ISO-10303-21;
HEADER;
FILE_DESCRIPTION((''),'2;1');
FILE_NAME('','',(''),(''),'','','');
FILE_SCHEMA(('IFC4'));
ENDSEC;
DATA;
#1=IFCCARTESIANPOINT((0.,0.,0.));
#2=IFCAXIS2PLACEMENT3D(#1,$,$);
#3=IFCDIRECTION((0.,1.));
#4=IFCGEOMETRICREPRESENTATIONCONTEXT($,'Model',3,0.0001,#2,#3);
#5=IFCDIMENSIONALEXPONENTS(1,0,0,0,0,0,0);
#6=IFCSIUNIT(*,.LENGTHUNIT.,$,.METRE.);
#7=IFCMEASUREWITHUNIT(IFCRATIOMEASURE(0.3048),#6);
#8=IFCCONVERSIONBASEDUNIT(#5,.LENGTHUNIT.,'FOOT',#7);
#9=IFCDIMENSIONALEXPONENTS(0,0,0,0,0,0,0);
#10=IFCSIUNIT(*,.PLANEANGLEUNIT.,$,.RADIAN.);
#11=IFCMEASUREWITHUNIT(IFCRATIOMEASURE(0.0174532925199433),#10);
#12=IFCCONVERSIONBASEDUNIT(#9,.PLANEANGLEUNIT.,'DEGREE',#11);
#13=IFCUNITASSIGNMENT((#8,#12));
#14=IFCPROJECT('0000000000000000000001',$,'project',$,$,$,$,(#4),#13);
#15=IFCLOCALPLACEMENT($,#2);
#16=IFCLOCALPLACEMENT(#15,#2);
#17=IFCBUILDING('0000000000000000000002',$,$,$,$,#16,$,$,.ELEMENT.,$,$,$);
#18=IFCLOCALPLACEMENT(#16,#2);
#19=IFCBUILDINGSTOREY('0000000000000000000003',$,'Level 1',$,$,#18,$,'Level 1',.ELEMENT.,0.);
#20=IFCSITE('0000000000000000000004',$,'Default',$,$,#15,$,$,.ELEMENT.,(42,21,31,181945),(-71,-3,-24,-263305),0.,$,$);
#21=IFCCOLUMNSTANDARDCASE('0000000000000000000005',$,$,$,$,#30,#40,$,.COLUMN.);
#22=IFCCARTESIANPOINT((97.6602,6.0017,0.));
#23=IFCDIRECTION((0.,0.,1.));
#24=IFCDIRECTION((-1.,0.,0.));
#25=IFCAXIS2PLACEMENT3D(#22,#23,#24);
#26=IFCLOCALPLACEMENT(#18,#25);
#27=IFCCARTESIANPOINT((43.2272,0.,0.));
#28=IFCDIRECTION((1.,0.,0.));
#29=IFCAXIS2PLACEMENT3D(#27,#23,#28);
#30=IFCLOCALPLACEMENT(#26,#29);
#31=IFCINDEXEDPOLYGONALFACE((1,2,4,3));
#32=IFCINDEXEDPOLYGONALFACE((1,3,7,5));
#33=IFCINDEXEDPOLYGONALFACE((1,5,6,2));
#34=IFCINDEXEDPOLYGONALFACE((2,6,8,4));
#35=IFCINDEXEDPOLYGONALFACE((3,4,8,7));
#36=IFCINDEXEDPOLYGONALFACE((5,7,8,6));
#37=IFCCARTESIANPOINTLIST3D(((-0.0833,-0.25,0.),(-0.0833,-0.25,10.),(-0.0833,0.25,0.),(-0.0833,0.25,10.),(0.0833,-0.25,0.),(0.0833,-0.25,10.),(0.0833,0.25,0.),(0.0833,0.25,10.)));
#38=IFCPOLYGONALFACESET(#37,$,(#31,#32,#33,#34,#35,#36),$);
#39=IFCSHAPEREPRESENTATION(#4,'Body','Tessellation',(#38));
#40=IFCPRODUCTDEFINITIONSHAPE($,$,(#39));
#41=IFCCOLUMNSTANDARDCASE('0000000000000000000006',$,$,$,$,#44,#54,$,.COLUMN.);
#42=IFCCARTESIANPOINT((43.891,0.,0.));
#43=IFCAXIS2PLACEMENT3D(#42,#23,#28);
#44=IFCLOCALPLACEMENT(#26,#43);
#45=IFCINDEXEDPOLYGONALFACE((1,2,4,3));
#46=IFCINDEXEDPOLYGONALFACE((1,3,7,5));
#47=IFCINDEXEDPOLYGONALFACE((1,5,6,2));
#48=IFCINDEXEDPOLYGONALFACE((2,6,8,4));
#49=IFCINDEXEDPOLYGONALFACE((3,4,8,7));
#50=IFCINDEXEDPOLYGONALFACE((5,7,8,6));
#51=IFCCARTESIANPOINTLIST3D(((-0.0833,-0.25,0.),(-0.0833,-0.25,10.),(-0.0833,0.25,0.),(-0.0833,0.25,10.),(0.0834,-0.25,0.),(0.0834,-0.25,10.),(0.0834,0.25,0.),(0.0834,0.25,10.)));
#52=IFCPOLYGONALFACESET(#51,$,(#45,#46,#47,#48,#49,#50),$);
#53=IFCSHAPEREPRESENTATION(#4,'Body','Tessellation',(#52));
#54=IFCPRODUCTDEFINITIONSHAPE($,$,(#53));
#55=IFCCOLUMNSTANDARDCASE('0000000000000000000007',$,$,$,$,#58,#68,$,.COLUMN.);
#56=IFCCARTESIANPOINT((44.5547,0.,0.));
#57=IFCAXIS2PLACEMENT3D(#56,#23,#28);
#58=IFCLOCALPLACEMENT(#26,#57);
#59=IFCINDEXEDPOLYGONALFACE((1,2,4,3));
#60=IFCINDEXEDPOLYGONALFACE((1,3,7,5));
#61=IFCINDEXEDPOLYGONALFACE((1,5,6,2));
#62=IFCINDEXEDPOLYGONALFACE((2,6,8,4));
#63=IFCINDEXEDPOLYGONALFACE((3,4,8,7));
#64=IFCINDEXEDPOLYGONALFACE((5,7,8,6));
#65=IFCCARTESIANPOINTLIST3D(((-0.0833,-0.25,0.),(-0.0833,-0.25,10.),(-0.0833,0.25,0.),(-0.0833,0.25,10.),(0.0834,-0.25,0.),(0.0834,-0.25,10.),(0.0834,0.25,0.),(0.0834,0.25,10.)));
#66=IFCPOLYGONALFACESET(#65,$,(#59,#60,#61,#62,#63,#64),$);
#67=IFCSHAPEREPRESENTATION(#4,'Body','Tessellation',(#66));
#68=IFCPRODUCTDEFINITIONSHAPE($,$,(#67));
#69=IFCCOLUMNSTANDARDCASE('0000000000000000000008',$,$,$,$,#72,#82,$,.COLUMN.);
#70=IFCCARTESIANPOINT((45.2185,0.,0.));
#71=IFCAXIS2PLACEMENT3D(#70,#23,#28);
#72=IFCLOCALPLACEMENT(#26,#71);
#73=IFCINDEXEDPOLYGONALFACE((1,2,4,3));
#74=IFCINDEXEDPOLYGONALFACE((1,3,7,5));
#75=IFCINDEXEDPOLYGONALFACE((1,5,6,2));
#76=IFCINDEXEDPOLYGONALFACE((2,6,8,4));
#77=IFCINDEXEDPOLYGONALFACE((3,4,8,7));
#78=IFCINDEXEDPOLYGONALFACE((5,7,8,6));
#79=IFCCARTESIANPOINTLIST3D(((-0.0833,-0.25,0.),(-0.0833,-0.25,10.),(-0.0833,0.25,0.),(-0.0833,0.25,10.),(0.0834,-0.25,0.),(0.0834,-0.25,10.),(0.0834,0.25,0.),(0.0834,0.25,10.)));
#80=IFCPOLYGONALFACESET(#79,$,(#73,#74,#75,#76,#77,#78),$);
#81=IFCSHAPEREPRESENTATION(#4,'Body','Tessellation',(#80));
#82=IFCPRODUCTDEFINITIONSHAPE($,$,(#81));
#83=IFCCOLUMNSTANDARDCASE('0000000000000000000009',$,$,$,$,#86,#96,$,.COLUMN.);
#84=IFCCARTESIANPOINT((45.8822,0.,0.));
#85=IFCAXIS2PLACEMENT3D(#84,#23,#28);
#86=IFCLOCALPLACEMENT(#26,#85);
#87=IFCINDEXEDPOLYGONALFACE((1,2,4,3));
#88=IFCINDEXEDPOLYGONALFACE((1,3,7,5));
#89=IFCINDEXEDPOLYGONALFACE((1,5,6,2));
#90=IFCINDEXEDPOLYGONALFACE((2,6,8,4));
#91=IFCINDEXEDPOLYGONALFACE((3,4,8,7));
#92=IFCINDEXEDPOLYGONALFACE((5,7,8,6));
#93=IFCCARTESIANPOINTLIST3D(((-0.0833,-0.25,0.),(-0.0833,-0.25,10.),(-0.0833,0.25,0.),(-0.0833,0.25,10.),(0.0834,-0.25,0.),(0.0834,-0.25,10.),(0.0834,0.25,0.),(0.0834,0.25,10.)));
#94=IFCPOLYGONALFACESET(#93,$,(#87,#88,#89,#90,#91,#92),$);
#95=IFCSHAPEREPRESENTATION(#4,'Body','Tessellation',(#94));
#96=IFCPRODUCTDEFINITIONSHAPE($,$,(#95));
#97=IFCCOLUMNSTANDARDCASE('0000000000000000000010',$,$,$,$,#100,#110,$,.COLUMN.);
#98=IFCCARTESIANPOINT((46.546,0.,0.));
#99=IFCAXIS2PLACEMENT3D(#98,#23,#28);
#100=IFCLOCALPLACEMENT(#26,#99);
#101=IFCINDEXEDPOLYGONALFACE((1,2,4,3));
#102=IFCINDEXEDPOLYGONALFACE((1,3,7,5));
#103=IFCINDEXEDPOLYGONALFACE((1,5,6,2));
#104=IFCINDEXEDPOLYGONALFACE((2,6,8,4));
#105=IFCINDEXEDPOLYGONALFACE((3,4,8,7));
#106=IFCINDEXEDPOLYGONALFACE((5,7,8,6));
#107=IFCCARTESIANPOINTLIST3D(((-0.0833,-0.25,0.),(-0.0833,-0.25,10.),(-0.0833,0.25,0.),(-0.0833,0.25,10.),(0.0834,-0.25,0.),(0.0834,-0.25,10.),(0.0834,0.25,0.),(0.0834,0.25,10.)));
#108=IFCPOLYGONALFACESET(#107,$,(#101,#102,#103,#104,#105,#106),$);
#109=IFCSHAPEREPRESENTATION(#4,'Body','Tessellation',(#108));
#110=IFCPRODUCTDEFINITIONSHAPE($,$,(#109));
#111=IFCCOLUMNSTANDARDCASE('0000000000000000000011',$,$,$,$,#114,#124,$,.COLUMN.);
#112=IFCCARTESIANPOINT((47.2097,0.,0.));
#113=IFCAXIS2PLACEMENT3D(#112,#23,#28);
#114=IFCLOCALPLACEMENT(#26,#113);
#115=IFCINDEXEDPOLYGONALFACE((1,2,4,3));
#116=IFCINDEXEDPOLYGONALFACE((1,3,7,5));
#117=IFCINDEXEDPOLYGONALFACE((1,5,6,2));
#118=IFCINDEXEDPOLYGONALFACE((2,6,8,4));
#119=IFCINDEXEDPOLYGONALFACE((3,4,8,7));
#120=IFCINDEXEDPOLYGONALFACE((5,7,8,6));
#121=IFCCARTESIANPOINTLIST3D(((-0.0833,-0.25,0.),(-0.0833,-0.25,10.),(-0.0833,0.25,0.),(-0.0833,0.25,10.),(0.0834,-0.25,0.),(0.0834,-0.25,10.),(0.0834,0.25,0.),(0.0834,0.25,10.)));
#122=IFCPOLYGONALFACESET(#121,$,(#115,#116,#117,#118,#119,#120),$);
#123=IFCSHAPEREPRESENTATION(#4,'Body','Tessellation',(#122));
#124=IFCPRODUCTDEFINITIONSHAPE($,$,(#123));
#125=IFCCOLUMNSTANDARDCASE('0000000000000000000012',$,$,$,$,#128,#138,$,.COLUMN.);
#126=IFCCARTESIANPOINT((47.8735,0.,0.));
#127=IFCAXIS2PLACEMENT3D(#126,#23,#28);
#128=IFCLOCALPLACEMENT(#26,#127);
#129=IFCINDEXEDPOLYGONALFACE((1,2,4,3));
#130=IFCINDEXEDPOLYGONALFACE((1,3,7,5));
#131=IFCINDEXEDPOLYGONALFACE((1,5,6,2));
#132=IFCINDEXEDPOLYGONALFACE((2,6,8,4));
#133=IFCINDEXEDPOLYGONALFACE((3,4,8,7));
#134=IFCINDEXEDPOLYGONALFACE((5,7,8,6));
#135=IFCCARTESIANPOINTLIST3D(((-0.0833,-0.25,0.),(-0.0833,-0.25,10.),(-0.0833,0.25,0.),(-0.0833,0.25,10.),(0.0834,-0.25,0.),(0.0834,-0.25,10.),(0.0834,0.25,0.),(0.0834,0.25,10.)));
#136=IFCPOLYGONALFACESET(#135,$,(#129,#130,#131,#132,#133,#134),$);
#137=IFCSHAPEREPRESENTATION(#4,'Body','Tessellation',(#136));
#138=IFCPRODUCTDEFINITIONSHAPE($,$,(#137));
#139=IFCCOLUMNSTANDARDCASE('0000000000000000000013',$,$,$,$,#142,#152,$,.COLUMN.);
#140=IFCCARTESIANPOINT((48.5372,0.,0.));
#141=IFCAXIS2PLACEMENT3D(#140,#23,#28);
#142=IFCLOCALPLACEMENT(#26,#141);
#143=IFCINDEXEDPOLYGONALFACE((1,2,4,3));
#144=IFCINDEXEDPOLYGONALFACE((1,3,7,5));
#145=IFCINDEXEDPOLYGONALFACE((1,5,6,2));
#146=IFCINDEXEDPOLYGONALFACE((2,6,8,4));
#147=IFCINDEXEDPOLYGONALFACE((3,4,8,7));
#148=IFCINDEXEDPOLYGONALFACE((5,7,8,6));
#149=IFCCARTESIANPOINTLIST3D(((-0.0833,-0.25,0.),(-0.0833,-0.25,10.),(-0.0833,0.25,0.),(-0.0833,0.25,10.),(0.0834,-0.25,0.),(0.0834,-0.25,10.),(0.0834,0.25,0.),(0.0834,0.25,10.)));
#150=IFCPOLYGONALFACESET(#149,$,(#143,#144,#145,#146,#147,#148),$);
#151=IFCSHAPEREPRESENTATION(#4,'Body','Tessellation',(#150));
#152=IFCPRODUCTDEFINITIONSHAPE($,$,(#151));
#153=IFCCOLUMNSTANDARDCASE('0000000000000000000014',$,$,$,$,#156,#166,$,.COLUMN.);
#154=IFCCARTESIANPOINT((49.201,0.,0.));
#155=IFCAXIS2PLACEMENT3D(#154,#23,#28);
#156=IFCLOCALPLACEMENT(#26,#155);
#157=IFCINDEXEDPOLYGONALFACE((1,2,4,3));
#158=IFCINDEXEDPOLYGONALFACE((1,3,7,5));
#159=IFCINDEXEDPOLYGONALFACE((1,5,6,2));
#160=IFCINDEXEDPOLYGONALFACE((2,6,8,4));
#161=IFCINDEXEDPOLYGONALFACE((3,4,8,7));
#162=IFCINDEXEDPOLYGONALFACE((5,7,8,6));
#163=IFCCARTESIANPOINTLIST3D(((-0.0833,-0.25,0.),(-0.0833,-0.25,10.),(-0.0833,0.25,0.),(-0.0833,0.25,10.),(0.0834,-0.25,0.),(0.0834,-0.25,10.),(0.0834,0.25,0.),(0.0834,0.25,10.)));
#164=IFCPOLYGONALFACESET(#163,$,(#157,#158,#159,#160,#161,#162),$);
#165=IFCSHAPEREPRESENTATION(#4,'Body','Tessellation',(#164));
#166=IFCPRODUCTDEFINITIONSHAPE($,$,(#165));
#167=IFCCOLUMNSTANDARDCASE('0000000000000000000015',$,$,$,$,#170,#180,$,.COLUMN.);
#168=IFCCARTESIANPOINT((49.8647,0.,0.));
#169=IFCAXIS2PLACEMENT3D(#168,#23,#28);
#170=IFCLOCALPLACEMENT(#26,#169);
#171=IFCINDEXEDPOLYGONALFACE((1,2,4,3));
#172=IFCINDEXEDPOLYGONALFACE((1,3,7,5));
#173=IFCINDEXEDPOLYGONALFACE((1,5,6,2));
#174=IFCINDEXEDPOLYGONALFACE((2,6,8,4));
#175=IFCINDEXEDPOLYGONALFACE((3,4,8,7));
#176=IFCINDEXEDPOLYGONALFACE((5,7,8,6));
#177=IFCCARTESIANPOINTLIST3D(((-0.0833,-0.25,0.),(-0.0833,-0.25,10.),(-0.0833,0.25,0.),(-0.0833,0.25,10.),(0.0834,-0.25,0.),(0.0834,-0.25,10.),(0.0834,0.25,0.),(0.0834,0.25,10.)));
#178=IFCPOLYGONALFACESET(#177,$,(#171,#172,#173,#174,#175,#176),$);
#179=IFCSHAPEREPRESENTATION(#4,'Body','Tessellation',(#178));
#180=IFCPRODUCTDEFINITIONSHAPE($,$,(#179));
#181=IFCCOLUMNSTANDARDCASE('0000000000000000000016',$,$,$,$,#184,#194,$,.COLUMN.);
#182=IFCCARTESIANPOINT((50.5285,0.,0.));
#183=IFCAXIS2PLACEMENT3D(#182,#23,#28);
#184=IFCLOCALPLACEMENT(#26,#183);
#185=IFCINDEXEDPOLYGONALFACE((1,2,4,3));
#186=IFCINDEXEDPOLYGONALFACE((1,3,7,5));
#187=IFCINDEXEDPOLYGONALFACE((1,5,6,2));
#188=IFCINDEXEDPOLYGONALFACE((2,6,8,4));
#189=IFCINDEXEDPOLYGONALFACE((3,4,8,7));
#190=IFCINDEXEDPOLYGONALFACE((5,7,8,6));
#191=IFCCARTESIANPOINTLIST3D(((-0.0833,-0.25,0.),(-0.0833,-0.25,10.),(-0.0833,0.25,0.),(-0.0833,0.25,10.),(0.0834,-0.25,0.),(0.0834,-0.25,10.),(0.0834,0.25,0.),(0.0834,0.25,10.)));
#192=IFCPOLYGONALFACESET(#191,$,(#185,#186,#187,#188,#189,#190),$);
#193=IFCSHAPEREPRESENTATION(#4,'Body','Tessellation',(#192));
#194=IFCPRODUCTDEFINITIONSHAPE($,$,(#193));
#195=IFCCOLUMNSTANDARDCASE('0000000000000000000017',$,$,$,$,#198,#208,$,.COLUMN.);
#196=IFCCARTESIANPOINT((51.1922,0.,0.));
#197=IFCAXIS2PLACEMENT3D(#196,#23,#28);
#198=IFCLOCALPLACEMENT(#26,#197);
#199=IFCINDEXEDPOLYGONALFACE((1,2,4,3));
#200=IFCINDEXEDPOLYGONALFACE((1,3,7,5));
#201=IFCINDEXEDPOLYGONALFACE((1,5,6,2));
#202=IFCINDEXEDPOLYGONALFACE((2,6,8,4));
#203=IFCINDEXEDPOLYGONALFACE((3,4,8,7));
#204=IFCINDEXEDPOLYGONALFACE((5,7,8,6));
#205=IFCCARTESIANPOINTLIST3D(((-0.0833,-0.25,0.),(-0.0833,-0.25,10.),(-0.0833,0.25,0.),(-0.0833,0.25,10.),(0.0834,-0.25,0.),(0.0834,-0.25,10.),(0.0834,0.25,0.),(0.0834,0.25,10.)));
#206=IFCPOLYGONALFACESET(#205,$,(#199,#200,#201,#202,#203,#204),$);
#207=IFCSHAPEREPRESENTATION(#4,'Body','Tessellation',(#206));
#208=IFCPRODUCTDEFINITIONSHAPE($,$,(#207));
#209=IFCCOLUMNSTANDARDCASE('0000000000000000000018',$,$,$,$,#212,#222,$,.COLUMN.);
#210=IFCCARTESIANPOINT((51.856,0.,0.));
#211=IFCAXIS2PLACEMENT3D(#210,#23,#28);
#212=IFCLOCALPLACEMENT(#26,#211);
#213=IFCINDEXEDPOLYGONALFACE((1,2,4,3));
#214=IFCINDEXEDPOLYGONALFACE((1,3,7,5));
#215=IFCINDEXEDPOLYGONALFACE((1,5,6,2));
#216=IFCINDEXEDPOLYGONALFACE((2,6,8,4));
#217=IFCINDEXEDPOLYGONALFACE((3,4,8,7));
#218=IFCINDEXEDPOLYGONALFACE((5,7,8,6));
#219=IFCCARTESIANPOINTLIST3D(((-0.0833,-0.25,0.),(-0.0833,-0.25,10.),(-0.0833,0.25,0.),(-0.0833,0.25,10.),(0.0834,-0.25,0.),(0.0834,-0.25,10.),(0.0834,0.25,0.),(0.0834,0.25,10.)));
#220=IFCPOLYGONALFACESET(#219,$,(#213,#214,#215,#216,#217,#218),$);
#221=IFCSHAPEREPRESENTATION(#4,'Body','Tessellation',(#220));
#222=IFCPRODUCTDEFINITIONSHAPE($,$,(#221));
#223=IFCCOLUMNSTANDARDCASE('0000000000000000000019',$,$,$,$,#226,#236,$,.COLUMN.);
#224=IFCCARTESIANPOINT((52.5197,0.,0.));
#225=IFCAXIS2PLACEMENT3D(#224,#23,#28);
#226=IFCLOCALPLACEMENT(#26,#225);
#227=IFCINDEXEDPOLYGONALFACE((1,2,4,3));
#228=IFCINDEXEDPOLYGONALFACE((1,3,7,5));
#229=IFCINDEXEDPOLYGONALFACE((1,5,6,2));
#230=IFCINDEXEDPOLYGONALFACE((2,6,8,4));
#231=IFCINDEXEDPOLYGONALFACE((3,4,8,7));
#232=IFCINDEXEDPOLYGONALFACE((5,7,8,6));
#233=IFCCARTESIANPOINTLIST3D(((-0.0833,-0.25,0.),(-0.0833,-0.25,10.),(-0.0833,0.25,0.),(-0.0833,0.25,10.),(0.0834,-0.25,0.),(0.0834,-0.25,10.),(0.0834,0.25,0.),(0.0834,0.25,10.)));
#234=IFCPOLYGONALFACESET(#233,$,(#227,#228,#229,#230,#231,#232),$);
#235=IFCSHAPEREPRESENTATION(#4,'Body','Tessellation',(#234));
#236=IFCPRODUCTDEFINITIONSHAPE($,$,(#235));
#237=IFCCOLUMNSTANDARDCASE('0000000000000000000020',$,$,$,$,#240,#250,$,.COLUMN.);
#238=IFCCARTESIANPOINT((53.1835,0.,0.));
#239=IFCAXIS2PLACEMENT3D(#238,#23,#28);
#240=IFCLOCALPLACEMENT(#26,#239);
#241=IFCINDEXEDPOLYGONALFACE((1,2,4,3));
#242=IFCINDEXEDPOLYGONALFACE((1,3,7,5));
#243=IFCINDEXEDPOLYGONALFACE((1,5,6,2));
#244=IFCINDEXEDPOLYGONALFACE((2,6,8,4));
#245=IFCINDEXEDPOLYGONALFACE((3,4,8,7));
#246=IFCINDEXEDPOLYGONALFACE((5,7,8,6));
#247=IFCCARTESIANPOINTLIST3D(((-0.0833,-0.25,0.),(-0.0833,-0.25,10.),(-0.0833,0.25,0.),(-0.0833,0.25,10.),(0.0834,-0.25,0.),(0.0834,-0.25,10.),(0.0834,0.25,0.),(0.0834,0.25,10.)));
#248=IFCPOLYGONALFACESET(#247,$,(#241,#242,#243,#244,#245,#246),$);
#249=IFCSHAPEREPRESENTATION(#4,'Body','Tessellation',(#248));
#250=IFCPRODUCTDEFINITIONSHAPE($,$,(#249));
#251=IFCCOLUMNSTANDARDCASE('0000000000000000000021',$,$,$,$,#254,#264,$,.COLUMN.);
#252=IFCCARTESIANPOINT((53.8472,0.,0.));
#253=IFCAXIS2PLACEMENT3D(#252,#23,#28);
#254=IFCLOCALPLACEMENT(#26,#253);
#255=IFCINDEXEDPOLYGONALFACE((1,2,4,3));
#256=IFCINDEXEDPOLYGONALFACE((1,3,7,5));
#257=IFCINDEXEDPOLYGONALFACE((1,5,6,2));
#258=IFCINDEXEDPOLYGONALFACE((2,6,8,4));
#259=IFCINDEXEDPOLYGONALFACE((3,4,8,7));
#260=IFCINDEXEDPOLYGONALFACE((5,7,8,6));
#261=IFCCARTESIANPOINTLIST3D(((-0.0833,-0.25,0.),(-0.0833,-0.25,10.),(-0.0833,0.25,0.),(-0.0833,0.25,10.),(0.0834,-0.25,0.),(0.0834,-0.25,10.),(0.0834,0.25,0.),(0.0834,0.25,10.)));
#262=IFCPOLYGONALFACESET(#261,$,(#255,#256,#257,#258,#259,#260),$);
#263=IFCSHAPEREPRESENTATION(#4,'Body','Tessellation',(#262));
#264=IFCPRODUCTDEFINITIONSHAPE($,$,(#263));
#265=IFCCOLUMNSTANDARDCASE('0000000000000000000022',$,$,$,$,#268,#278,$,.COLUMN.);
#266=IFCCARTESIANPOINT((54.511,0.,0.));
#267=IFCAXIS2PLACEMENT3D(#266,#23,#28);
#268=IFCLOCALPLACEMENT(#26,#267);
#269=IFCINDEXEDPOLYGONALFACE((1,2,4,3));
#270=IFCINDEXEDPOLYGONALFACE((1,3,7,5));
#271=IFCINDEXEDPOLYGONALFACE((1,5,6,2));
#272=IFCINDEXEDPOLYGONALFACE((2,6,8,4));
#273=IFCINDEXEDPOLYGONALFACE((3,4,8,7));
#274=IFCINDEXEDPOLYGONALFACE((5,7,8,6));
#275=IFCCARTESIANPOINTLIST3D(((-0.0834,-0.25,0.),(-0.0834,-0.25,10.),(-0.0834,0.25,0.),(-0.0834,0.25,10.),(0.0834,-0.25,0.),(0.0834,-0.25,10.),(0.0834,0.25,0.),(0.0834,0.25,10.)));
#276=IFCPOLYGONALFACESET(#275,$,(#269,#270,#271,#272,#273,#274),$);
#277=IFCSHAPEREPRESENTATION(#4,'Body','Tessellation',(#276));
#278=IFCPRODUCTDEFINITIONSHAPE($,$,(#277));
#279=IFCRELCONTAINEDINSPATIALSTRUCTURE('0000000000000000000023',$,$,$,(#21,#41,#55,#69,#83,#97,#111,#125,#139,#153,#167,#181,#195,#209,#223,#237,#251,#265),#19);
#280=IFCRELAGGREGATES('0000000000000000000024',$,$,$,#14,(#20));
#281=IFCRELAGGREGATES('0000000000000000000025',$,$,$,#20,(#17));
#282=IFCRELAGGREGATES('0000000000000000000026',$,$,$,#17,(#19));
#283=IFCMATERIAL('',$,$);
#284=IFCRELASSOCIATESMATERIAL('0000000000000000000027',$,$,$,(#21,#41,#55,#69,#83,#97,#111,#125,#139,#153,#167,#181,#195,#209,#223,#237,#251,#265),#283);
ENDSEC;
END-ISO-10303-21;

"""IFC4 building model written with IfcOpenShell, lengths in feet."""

from ifc_helpers import new_model, entity, si_unit, converted_unit, direction, frame, origin, place, context, project, spatial, rectangle, extrude, material, element, save


model = new_model("IFC4")

# Units and contexts
model_context = context("Model", 3, precision=0.0001, world=origin(), true_north=direction((0.0, 1.0)))
ifc_project = project(units=[converted_unit("LENGTHUNIT", "FOOT", entity("IfcRatioMeasure", 0.3048), si_unit("LENGTHUNIT", "METRE"), dimensions=[1, 0, 0, 0, 0, 0, 0]), converted_unit("PLANEANGLEUNIT", "DEGREE", entity("IfcRatioMeasure", 0.0174532925199433), si_unit("PLANEANGLEUNIT", "RADIAN"), dimensions=[0, 0, 0, 0, 0, 0, 0])], contexts=[model_context])

# Site, building, storey
site_placement = place(None, origin())
site = spatial("IfcSite", under=ifc_project, at=site_placement, Name="Default", CompositionType="ELEMENT", RefLatitude=(42, 21, 31, 181945), RefLongitude=(-71, -3, -24, -263305), RefElevation=0.0)
building_placement = place(site_placement, origin())
building = spatial("IfcBuilding", under=site, at=building_placement, CompositionType="ELEMENT")
storey_placement = place(building_placement, origin())
storey = spatial("IfcBuildingStorey", under=building, at=storey_placement, Name="Level 1", LongName="Level 1", CompositionType="ELEMENT", Elevation=0.0)

# Columns
ifc_material = material(Name="")
placement = place(storey_placement, frame((97.6602, 6.0017, 0.0), z_axis=(0.0, 0.0, 1.0), x_axis=(-1.0, 0.0, 0.0)))
for number, where, z_axis, x_axis in (
    (1, (43.2272, 0.0, 0.0), (0.0, 0.0, 1.0), (1.0, 0.0, 0.0)),
    (2, (43.891, 0.0, 0.0), (0.0, 0.0, 1.0), (1.0, 0.0, 0.0)),
    (3, (44.5547, 0.0, 0.0), (0.0, 0.0, 1.0), (1.0, 0.0, 0.0)),
    (4, (45.2185, 0.0, 0.0), (0.0, 0.0, 1.0), (1.0, 0.0, 0.0)),
    (5, (45.8822, 0.0, 0.0), (0.0, 0.0, 1.0), (1.0, 0.0, 0.0)),
    (6, (46.546, 0.0, 0.0), (0.0, 0.0, 1.0), (1.0, 0.0, 0.0)),
    (7, (47.2097, 0.0, 0.0), (0.0, 0.0, 1.0), (1.0, 0.0, 0.0)),
    (8, (47.8735, 0.0, 0.0), (0.0, 0.0, 1.0), (1.0, 0.0, 0.0)),
    (9, (48.5372, 0.0, 0.0), (0.0, 0.0, 1.0), (1.0, 0.0, 0.0)),
    (10, (49.201, 0.0, 0.0), (0.0, 0.0, 1.0), (1.0, 0.0, 0.0)),
    (11, (49.8647, 0.0, 0.0), (0.0, 0.0, 1.0), (1.0, 0.0, 0.0)),
    (12, (50.5285, 0.0, 0.0), (0.0, 0.0, 1.0), (1.0, 0.0, 0.0)),
    (13, (51.1922, 0.0, 0.0), (0.0, 0.0, 1.0), (1.0, 0.0, 0.0)),
    (14, (51.856, 0.0, 0.0), (0.0, 0.0, 1.0), (1.0, 0.0, 0.0)),
    (15, (52.5197, 0.0, 0.0), (0.0, 0.0, 1.0), (1.0, 0.0, 0.0)),
    (16, (53.1835, 0.0, 0.0), (0.0, 0.0, 1.0), (1.0, 0.0, 0.0)),
    (17, (53.8472, 0.0, 0.0), (0.0, 0.0, 1.0), (1.0, 0.0, 0.0)),
    (18, (54.511, 0.0, 0.0), (0.0, 0.0, 1.0), (1.0, 0.0, 0.0)),
):
    element("IfcColumnStandardCase", number, at=place(placement, frame(where, z_axis=z_axis, x_axis=x_axis)), inside=storey, material=ifc_material, PredefinedType="COLUMN", context=model_context, shape_type="SweptSolid", body=[
        extrude(rectangle(XDim=0.1667, YDim=0.5), origin(), (0.0, 0.0, 1.0), 10.0),
    ])

save(model, "model.ifc")
